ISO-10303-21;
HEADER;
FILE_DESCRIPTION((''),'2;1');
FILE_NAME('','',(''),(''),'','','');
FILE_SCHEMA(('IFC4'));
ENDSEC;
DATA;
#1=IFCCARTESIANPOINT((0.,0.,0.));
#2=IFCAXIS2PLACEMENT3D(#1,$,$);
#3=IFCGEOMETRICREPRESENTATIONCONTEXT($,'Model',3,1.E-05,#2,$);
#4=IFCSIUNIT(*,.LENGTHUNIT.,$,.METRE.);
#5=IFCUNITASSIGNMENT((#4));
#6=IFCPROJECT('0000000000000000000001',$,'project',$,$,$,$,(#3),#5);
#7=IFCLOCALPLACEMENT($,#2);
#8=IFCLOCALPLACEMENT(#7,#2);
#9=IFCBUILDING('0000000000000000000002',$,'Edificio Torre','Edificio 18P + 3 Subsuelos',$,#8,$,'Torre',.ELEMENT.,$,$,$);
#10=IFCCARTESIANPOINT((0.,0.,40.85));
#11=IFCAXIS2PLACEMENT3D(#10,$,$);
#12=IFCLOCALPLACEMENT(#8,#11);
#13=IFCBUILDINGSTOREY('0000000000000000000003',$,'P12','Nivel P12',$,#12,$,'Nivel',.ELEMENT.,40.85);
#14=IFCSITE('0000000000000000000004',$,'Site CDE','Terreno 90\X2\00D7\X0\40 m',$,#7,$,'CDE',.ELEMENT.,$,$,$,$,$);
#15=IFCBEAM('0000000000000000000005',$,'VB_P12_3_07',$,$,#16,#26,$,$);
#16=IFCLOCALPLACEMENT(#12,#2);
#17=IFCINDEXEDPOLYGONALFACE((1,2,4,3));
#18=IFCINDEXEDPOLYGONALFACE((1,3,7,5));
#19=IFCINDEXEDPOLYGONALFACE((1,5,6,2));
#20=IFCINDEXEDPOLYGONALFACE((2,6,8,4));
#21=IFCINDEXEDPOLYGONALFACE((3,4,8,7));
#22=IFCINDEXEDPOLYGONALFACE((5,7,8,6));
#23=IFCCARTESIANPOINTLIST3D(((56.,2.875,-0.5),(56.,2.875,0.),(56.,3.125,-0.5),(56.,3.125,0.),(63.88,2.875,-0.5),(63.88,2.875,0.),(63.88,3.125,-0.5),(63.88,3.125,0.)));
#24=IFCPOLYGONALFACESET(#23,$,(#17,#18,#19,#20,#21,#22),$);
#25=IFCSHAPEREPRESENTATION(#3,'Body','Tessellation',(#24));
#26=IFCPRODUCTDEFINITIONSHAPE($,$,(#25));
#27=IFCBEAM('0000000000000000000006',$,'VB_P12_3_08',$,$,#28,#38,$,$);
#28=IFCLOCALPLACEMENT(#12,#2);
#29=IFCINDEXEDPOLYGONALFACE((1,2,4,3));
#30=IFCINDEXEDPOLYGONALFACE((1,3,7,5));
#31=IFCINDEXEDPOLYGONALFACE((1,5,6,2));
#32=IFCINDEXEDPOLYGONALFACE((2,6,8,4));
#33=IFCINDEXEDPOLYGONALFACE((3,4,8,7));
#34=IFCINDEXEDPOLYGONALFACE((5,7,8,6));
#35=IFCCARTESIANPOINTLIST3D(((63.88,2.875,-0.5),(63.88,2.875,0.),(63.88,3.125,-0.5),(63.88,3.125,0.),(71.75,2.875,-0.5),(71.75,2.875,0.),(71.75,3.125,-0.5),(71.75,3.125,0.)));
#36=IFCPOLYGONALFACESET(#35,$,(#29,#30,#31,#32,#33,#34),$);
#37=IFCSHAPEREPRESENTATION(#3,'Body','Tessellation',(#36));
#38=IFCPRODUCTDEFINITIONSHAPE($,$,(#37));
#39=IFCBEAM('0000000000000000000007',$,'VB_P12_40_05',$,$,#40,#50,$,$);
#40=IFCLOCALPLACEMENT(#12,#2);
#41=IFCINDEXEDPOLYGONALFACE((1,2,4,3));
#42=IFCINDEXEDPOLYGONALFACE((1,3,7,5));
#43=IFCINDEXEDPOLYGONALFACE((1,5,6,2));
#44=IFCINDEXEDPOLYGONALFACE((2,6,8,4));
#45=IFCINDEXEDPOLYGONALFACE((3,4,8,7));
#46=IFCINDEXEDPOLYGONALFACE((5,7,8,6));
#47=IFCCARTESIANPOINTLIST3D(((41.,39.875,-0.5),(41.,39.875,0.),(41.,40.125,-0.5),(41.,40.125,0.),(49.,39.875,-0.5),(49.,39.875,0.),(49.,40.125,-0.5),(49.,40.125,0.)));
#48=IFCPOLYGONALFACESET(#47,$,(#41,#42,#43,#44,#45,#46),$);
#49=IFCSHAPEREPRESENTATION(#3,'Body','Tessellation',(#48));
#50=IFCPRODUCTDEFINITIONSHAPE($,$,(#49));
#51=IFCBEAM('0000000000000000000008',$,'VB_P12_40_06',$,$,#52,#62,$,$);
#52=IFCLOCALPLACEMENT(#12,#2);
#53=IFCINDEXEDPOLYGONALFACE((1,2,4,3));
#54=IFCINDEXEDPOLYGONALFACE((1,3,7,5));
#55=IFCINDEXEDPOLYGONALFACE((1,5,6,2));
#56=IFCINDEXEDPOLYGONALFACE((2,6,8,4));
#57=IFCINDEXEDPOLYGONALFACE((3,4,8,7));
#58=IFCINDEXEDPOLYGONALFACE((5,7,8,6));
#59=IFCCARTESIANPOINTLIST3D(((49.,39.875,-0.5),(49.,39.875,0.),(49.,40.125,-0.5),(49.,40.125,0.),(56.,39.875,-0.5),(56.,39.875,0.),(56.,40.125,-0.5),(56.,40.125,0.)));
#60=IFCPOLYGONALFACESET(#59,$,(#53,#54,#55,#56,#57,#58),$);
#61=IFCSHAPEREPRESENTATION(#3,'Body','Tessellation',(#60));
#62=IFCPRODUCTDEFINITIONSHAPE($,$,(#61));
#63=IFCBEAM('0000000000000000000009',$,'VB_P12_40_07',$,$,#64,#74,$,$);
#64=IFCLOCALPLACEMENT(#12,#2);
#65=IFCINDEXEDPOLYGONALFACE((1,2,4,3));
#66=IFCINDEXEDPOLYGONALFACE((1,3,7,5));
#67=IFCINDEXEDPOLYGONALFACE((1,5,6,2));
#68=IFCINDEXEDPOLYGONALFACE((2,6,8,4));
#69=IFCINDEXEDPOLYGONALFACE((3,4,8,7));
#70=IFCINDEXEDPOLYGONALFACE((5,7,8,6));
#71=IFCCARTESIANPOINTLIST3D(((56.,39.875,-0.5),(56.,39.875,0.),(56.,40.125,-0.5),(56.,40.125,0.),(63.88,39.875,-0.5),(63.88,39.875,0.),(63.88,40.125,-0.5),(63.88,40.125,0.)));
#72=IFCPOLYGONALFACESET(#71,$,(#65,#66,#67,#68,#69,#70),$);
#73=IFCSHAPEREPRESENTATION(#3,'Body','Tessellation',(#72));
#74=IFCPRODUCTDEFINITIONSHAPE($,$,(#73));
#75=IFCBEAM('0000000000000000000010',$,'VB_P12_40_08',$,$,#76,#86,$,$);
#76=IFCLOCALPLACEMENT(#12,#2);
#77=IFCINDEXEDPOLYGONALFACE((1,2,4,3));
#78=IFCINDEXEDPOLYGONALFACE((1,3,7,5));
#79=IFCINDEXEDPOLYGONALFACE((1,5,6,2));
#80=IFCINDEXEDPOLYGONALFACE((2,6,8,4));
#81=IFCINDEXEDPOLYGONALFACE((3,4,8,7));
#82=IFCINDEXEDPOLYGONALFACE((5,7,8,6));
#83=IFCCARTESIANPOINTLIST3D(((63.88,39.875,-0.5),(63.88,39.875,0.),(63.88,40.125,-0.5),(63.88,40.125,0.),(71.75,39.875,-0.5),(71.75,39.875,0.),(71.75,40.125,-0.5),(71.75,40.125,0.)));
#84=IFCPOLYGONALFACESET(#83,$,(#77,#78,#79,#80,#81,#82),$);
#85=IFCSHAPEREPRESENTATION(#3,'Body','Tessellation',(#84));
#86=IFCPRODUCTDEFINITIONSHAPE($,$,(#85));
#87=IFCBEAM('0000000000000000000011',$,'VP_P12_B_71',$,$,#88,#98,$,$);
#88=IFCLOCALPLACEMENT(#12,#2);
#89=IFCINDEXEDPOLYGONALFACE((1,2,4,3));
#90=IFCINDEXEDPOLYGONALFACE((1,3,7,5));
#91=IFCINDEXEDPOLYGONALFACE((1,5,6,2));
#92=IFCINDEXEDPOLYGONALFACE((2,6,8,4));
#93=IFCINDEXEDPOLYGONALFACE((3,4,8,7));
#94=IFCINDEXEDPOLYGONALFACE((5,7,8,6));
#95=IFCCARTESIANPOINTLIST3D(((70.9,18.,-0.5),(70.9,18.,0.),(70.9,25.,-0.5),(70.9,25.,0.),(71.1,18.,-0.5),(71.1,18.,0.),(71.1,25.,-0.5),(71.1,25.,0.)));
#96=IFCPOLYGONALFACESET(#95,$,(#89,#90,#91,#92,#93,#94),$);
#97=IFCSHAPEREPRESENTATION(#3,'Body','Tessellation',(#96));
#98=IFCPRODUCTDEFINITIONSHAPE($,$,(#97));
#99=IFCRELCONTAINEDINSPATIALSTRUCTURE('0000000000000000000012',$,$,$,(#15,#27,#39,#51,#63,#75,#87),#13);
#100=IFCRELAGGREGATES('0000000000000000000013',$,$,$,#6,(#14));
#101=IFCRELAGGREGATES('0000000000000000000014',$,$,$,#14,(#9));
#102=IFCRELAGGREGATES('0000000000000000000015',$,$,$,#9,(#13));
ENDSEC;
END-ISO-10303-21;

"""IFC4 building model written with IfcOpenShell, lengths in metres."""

from ifc_helpers import new_model, si_unit, frame, origin, origin_2d, place, context, project, spatial, rectangle, extrude, element, save


model = new_model("IFC4")

# Units and contexts
model_context = context("Model", 3, precision=1e-05, world=origin())
ifc_project = project(units=[si_unit("LENGTHUNIT", "METRE")], contexts=[model_context])

# Site, building, storey
site_placement = place(None, origin())
site = spatial("IfcSite", under=ifc_project, at=site_placement, Name="Site CDE", Description="Terreno 90×40 m", LongName="CDE", CompositionType="ELEMENT")
building_placement = place(site_placement, origin())
building = spatial("IfcBuilding", under=site, at=building_placement, Name="Edificio Torre", Description="Edificio 18P + 3 Subsuelos", LongName="Torre", CompositionType="ELEMENT")
storey_placement = place(building_placement, frame((0.0, 0.0, 40.85)))
storey = spatial("IfcBuildingStorey", under=building, at=storey_placement, Name="P12", Description="Nivel P12", LongName="Nivel", CompositionType="ELEMENT", Elevation=40.85)

# Beams
beam_1_placement = place(storey_placement, frame((59.94, 3.0, -0.5)))
element("IfcBeam", 1, at=beam_1_placement, inside=storey, Name="VB_P12_3_07", context=model_context, shape_type="SweptSolid", body=[
    extrude(rectangle(XDim=7.88, YDim=0.25, at=origin_2d()), origin(), (0.0, 0.0, 1.0), 0.5),
])
beam_2_placement = place(storey_placement, frame((67.815, 3.0, -0.5)))
element("IfcBeam", 2, at=beam_2_placement, inside=storey, Name="VB_P12_3_08", context=model_context, shape_type="SweptSolid", body=[
    extrude(rectangle(XDim=7.87, YDim=0.25, at=origin_2d()), origin(), (0.0, 0.0, 1.0), 0.5),
])
beam_3_placement = place(storey_placement, frame((45.0, 40.0, -0.5)))
element("IfcBeam", 3, at=beam_3_placement, inside=storey, Name="VB_P12_40_05", context=model_context, shape_type="SweptSolid", body=[
    extrude(rectangle(XDim=8.0, YDim=0.25, at=origin_2d()), origin(), (0.0, 0.0, 1.0), 0.5),
])
beam_4_placement = place(storey_placement, frame((52.5, 40.0, -0.5)))
element("IfcBeam", 4, at=beam_4_placement, inside=storey, Name="VB_P12_40_06", context=model_context, shape_type="SweptSolid", body=[
    extrude(rectangle(XDim=7.0, YDim=0.25, at=origin_2d()), origin(), (0.0, 0.0, 1.0), 0.5),
])
beam_5_placement = place(storey_placement, frame((59.94, 40.0, -0.5)))
element("IfcBeam", 5, at=beam_5_placement, inside=storey, Name="VB_P12_40_07", context=model_context, shape_type="SweptSolid", body=[
    extrude(rectangle(XDim=7.88, YDim=0.25, at=origin_2d()), origin(), (0.0, 0.0, 1.0), 0.5),
])
beam_6_placement = place(storey_placement, frame((67.815, 40.0, -0.5)))
element("IfcBeam", 6, at=beam_6_placement, inside=storey, Name="VB_P12_40_08", context=model_context, shape_type="SweptSolid", body=[
    extrude(rectangle(XDim=7.87, YDim=0.25, at=origin_2d()), origin(), (0.0, 0.0, 1.0), 0.5),
])
beam_7_placement = place(storey_placement, frame((71.0, 21.5, -0.5)))
element("IfcBeam", 7, at=beam_7_placement, inside=storey, Name="VP_P12_B_71", context=model_context, shape_type="SweptSolid", body=[
    extrude(rectangle(XDim=0.2, YDim=7.0, at=origin_2d()), origin(), (0.0, 0.0, 1.0), 0.5),
])

save(model, "model.ifc")
